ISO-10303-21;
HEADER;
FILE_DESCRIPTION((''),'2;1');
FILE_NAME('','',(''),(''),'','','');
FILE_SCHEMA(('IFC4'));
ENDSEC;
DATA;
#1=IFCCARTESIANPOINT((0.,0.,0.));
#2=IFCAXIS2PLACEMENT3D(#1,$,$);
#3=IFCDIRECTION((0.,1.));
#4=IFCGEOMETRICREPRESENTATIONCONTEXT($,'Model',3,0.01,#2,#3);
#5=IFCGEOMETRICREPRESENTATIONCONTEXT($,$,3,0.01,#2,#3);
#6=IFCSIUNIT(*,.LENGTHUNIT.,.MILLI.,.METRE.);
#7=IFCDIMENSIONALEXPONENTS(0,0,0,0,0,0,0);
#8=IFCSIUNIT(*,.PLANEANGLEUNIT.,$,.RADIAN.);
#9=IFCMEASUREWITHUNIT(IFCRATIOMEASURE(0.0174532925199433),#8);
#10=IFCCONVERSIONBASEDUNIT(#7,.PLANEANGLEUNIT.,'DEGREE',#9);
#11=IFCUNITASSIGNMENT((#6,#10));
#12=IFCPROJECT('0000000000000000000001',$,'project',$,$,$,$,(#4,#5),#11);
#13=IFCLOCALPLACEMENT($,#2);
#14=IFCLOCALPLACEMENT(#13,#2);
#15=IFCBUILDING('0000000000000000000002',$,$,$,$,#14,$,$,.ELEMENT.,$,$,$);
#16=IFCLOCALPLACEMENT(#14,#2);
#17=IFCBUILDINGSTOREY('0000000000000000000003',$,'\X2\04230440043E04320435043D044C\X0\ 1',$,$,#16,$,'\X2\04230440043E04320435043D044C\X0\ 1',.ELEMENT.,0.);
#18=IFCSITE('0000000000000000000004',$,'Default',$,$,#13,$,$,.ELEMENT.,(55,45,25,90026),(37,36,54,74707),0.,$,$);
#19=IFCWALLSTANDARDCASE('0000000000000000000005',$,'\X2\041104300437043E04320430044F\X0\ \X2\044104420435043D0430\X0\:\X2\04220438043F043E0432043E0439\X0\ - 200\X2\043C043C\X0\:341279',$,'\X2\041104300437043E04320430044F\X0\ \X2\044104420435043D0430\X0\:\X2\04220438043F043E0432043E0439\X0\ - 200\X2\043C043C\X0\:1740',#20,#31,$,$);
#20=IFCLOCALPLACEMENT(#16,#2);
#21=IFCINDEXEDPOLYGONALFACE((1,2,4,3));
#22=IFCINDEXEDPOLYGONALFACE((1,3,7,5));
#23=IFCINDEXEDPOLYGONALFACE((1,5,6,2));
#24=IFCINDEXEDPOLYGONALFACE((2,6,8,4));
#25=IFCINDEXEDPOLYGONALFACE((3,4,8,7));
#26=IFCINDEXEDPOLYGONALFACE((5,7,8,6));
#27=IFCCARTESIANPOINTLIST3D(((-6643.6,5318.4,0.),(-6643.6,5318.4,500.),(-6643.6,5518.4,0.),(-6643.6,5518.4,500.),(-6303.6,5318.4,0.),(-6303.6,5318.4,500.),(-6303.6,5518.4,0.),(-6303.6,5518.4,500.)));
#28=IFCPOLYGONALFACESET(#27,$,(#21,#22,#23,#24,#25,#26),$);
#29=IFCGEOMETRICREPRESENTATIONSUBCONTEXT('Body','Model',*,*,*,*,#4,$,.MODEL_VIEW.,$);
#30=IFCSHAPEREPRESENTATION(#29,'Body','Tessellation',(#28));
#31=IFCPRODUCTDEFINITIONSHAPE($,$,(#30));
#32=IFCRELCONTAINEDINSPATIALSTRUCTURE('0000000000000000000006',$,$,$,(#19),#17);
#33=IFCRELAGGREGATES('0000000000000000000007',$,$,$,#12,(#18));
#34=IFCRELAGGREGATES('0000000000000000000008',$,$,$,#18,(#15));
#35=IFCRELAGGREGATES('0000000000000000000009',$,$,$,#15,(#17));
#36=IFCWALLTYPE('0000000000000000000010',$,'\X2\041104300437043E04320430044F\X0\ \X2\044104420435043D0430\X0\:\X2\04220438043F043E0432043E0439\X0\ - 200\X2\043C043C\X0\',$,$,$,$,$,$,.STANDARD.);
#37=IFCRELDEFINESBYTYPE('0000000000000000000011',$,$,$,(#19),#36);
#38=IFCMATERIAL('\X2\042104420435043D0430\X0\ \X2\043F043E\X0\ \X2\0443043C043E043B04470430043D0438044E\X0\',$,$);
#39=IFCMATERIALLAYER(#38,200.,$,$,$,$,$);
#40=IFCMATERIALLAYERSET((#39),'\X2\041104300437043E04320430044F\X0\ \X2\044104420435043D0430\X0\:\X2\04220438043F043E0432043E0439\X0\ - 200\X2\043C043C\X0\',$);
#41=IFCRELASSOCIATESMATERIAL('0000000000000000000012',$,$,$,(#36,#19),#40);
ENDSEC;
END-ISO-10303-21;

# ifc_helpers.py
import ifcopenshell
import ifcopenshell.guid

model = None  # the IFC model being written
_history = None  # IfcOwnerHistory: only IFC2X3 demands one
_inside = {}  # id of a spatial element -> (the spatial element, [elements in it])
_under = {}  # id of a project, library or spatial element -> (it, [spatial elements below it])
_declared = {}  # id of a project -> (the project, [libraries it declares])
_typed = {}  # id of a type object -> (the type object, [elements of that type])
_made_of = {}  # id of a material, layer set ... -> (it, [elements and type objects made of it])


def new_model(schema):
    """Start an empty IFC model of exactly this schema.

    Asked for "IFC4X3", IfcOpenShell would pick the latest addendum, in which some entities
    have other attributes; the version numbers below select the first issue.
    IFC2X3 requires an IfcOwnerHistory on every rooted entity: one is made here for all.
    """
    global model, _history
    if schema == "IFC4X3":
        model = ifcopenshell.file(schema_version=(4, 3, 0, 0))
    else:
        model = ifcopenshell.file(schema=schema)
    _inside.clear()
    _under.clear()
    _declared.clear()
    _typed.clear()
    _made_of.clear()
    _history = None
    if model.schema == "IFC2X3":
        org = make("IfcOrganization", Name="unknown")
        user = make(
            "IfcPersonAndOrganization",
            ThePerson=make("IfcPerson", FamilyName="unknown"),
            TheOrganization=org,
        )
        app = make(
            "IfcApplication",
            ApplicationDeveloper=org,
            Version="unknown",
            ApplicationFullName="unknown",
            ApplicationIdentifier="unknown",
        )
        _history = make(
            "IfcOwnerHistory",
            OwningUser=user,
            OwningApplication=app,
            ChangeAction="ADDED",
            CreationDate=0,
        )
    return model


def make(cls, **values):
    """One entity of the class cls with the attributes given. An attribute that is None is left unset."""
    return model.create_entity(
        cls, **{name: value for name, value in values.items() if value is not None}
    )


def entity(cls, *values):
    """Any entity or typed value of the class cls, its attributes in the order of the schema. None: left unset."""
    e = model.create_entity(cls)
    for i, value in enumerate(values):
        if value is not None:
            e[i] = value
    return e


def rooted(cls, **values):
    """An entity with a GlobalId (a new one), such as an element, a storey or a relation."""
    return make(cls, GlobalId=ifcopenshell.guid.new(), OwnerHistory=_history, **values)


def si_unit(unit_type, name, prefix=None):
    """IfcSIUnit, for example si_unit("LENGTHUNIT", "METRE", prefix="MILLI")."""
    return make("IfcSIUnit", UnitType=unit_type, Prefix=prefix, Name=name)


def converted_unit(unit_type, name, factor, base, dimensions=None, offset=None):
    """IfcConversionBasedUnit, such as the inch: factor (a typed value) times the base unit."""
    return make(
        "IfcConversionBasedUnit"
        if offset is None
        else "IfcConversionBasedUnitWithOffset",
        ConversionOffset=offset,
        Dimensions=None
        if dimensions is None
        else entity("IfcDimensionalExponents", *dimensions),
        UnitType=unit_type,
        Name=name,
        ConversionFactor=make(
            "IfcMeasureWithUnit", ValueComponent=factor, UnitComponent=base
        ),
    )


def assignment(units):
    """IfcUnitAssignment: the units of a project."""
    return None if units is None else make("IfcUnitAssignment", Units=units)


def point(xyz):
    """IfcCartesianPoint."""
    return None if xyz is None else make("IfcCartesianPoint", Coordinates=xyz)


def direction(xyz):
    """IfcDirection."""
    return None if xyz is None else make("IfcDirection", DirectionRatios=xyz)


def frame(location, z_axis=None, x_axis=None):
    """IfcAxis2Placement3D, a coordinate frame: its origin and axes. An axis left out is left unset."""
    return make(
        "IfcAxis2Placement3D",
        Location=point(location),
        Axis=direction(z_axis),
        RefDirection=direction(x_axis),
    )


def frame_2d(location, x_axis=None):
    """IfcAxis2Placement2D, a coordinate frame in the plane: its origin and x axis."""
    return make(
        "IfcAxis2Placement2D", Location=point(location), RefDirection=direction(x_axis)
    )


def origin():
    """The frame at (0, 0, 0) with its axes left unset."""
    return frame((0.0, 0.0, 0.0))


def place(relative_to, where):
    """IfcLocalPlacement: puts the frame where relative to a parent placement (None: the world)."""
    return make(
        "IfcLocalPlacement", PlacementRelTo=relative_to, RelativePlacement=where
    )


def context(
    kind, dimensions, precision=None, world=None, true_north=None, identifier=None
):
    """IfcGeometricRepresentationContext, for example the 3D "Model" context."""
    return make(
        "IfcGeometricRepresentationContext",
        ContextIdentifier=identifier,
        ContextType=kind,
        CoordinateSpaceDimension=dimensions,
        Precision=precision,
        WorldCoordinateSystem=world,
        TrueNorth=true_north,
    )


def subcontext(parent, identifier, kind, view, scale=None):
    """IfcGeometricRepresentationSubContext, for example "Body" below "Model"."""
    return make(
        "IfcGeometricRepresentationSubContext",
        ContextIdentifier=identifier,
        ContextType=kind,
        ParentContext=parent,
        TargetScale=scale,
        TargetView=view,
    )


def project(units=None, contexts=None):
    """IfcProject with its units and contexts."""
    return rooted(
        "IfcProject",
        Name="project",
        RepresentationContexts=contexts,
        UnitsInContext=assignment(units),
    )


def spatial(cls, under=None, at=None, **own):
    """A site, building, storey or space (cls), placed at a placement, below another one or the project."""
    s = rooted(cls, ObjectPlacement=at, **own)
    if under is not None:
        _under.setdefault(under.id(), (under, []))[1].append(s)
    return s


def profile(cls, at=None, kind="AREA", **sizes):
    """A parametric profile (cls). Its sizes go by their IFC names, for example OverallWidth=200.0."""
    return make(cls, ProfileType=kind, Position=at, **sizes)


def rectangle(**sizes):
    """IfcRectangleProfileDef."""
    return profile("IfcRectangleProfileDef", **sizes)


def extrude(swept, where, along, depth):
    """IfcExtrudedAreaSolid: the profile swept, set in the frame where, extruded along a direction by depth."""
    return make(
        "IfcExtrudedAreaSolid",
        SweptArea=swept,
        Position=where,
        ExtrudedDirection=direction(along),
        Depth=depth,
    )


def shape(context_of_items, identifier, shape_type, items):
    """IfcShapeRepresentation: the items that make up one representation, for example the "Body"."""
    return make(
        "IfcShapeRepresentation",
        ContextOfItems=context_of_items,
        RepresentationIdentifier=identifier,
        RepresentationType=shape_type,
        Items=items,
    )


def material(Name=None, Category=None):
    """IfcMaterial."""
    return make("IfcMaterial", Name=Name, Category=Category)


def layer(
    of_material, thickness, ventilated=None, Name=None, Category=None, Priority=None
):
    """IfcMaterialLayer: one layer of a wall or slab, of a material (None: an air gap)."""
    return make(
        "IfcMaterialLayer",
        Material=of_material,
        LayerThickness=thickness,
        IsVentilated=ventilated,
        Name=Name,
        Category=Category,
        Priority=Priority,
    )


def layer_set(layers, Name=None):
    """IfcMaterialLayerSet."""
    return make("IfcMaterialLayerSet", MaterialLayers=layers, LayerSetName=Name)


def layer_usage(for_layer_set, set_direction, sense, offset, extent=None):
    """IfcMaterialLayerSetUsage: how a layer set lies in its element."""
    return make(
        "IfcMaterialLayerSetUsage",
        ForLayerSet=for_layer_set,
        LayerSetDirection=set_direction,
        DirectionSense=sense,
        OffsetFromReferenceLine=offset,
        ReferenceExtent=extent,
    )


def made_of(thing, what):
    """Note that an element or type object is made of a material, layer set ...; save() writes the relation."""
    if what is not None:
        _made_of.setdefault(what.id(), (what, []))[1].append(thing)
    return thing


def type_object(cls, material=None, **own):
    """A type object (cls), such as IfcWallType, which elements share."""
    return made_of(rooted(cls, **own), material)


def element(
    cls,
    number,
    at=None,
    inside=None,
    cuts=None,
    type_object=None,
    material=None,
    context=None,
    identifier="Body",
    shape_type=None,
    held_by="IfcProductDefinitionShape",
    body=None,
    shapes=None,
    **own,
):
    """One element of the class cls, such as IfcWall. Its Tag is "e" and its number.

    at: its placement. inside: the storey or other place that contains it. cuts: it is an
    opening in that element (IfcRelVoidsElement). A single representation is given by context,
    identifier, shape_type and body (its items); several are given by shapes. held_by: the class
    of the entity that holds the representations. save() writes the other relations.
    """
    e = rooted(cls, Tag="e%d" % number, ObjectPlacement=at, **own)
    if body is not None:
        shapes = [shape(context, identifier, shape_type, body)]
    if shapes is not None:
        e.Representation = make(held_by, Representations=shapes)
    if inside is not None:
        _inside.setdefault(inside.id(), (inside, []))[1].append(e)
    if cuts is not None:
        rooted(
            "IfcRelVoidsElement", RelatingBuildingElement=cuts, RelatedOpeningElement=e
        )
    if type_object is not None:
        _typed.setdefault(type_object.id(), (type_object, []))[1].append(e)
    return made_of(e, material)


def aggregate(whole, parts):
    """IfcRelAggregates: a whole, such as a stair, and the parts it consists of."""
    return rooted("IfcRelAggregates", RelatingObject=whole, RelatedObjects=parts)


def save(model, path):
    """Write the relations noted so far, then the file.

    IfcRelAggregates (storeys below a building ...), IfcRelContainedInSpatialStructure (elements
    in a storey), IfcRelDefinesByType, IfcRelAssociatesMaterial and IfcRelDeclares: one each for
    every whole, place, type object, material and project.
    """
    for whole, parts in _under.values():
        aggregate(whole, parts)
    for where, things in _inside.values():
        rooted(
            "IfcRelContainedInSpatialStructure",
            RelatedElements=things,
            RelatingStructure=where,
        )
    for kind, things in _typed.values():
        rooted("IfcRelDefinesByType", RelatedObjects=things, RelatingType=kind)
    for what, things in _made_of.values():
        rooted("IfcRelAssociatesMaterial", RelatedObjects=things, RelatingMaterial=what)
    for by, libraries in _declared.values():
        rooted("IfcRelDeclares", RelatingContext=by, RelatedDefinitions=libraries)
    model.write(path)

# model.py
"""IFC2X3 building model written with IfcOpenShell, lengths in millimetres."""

from ifc_helpers import new_model, entity, si_unit, converted_unit, direction, frame, frame_2d, origin, place, context, subcontext, project, spatial, rectangle, extrude, material, layer, layer_set, layer_usage, type_object, element, save


model = new_model("IFC2X3")

# Units and contexts
model_context = context("Model", 3, precision=0.01, world=origin(), true_north=direction((0.0, 1.0)))
context_of_model = context(None, 3, precision=0.01, world=origin(), true_north=direction((0.0, 1.0)))
body_context = subcontext(model_context, "Body", "Model", "MODEL_VIEW")
ifc_project = project(units=[si_unit("LENGTHUNIT", "METRE", prefix="MILLI"), converted_unit("PLANEANGLEUNIT", "DEGREE", entity("IfcRatioMeasure", 0.0174532925199433), si_unit("PLANEANGLEUNIT", "RADIAN"), dimensions=[0, 0, 0, 0, 0, 0, 0])], contexts=[model_context, context_of_model])

# Site, building, storey
site_placement = place(None, origin())
site = spatial("IfcSite", under=ifc_project, at=site_placement, Name="Default", CompositionType="ELEMENT", RefLatitude=(55, 45, 25, 90026), RefLongitude=(37, 36, 54, 74707), RefElevation=0.0)
building_placement = place(site_placement, origin())
building = spatial("IfcBuilding", under=site, at=building_placement, CompositionType="ELEMENT")
storey_placement = place(building_placement, origin())
storey = spatial("IfcBuildingStorey", under=building, at=storey_placement, Name="Уровень 1", LongName="Уровень 1", CompositionType="ELEMENT", Elevation=0.0)

# Wall
ifc_material = material(Name="Стена по умолчанию")
ifc_layer = layer(ifc_material, 200.0)
ifc_layer_set = layer_set([ifc_layer], Name="Базовая стена:Типовой - 200мм")
ifc_layer_usage = layer_usage(ifc_layer_set, "AXIS2", "NEGATIVE", 100.0)
wall_type = type_object("IfcWallType", Name="Базовая стена:Типовой - 200мм", PredefinedType="STANDARD", material=ifc_layer_set)
wall_placement = place(storey_placement, frame((-6643.6, 5418.4, 0.0)))
element("IfcWallStandardCase", 1, at=wall_placement, inside=storey, type_object=wall_type, material=ifc_layer_usage, Name="Базовая стена:Типовой - 200мм:341279", ObjectType="Базовая стена:Типовой - 200мм:1740", context=body_context, shape_type="SweptSolid", body=[
    extrude(rectangle(XDim=340.0, YDim=200.0, at=frame_2d((170.0, 0.0), x_axis=(-1.0, 0.0))), origin(), (0.0, 0.0, 1.0), 500.0),
])

save(model, "model.ifc")
